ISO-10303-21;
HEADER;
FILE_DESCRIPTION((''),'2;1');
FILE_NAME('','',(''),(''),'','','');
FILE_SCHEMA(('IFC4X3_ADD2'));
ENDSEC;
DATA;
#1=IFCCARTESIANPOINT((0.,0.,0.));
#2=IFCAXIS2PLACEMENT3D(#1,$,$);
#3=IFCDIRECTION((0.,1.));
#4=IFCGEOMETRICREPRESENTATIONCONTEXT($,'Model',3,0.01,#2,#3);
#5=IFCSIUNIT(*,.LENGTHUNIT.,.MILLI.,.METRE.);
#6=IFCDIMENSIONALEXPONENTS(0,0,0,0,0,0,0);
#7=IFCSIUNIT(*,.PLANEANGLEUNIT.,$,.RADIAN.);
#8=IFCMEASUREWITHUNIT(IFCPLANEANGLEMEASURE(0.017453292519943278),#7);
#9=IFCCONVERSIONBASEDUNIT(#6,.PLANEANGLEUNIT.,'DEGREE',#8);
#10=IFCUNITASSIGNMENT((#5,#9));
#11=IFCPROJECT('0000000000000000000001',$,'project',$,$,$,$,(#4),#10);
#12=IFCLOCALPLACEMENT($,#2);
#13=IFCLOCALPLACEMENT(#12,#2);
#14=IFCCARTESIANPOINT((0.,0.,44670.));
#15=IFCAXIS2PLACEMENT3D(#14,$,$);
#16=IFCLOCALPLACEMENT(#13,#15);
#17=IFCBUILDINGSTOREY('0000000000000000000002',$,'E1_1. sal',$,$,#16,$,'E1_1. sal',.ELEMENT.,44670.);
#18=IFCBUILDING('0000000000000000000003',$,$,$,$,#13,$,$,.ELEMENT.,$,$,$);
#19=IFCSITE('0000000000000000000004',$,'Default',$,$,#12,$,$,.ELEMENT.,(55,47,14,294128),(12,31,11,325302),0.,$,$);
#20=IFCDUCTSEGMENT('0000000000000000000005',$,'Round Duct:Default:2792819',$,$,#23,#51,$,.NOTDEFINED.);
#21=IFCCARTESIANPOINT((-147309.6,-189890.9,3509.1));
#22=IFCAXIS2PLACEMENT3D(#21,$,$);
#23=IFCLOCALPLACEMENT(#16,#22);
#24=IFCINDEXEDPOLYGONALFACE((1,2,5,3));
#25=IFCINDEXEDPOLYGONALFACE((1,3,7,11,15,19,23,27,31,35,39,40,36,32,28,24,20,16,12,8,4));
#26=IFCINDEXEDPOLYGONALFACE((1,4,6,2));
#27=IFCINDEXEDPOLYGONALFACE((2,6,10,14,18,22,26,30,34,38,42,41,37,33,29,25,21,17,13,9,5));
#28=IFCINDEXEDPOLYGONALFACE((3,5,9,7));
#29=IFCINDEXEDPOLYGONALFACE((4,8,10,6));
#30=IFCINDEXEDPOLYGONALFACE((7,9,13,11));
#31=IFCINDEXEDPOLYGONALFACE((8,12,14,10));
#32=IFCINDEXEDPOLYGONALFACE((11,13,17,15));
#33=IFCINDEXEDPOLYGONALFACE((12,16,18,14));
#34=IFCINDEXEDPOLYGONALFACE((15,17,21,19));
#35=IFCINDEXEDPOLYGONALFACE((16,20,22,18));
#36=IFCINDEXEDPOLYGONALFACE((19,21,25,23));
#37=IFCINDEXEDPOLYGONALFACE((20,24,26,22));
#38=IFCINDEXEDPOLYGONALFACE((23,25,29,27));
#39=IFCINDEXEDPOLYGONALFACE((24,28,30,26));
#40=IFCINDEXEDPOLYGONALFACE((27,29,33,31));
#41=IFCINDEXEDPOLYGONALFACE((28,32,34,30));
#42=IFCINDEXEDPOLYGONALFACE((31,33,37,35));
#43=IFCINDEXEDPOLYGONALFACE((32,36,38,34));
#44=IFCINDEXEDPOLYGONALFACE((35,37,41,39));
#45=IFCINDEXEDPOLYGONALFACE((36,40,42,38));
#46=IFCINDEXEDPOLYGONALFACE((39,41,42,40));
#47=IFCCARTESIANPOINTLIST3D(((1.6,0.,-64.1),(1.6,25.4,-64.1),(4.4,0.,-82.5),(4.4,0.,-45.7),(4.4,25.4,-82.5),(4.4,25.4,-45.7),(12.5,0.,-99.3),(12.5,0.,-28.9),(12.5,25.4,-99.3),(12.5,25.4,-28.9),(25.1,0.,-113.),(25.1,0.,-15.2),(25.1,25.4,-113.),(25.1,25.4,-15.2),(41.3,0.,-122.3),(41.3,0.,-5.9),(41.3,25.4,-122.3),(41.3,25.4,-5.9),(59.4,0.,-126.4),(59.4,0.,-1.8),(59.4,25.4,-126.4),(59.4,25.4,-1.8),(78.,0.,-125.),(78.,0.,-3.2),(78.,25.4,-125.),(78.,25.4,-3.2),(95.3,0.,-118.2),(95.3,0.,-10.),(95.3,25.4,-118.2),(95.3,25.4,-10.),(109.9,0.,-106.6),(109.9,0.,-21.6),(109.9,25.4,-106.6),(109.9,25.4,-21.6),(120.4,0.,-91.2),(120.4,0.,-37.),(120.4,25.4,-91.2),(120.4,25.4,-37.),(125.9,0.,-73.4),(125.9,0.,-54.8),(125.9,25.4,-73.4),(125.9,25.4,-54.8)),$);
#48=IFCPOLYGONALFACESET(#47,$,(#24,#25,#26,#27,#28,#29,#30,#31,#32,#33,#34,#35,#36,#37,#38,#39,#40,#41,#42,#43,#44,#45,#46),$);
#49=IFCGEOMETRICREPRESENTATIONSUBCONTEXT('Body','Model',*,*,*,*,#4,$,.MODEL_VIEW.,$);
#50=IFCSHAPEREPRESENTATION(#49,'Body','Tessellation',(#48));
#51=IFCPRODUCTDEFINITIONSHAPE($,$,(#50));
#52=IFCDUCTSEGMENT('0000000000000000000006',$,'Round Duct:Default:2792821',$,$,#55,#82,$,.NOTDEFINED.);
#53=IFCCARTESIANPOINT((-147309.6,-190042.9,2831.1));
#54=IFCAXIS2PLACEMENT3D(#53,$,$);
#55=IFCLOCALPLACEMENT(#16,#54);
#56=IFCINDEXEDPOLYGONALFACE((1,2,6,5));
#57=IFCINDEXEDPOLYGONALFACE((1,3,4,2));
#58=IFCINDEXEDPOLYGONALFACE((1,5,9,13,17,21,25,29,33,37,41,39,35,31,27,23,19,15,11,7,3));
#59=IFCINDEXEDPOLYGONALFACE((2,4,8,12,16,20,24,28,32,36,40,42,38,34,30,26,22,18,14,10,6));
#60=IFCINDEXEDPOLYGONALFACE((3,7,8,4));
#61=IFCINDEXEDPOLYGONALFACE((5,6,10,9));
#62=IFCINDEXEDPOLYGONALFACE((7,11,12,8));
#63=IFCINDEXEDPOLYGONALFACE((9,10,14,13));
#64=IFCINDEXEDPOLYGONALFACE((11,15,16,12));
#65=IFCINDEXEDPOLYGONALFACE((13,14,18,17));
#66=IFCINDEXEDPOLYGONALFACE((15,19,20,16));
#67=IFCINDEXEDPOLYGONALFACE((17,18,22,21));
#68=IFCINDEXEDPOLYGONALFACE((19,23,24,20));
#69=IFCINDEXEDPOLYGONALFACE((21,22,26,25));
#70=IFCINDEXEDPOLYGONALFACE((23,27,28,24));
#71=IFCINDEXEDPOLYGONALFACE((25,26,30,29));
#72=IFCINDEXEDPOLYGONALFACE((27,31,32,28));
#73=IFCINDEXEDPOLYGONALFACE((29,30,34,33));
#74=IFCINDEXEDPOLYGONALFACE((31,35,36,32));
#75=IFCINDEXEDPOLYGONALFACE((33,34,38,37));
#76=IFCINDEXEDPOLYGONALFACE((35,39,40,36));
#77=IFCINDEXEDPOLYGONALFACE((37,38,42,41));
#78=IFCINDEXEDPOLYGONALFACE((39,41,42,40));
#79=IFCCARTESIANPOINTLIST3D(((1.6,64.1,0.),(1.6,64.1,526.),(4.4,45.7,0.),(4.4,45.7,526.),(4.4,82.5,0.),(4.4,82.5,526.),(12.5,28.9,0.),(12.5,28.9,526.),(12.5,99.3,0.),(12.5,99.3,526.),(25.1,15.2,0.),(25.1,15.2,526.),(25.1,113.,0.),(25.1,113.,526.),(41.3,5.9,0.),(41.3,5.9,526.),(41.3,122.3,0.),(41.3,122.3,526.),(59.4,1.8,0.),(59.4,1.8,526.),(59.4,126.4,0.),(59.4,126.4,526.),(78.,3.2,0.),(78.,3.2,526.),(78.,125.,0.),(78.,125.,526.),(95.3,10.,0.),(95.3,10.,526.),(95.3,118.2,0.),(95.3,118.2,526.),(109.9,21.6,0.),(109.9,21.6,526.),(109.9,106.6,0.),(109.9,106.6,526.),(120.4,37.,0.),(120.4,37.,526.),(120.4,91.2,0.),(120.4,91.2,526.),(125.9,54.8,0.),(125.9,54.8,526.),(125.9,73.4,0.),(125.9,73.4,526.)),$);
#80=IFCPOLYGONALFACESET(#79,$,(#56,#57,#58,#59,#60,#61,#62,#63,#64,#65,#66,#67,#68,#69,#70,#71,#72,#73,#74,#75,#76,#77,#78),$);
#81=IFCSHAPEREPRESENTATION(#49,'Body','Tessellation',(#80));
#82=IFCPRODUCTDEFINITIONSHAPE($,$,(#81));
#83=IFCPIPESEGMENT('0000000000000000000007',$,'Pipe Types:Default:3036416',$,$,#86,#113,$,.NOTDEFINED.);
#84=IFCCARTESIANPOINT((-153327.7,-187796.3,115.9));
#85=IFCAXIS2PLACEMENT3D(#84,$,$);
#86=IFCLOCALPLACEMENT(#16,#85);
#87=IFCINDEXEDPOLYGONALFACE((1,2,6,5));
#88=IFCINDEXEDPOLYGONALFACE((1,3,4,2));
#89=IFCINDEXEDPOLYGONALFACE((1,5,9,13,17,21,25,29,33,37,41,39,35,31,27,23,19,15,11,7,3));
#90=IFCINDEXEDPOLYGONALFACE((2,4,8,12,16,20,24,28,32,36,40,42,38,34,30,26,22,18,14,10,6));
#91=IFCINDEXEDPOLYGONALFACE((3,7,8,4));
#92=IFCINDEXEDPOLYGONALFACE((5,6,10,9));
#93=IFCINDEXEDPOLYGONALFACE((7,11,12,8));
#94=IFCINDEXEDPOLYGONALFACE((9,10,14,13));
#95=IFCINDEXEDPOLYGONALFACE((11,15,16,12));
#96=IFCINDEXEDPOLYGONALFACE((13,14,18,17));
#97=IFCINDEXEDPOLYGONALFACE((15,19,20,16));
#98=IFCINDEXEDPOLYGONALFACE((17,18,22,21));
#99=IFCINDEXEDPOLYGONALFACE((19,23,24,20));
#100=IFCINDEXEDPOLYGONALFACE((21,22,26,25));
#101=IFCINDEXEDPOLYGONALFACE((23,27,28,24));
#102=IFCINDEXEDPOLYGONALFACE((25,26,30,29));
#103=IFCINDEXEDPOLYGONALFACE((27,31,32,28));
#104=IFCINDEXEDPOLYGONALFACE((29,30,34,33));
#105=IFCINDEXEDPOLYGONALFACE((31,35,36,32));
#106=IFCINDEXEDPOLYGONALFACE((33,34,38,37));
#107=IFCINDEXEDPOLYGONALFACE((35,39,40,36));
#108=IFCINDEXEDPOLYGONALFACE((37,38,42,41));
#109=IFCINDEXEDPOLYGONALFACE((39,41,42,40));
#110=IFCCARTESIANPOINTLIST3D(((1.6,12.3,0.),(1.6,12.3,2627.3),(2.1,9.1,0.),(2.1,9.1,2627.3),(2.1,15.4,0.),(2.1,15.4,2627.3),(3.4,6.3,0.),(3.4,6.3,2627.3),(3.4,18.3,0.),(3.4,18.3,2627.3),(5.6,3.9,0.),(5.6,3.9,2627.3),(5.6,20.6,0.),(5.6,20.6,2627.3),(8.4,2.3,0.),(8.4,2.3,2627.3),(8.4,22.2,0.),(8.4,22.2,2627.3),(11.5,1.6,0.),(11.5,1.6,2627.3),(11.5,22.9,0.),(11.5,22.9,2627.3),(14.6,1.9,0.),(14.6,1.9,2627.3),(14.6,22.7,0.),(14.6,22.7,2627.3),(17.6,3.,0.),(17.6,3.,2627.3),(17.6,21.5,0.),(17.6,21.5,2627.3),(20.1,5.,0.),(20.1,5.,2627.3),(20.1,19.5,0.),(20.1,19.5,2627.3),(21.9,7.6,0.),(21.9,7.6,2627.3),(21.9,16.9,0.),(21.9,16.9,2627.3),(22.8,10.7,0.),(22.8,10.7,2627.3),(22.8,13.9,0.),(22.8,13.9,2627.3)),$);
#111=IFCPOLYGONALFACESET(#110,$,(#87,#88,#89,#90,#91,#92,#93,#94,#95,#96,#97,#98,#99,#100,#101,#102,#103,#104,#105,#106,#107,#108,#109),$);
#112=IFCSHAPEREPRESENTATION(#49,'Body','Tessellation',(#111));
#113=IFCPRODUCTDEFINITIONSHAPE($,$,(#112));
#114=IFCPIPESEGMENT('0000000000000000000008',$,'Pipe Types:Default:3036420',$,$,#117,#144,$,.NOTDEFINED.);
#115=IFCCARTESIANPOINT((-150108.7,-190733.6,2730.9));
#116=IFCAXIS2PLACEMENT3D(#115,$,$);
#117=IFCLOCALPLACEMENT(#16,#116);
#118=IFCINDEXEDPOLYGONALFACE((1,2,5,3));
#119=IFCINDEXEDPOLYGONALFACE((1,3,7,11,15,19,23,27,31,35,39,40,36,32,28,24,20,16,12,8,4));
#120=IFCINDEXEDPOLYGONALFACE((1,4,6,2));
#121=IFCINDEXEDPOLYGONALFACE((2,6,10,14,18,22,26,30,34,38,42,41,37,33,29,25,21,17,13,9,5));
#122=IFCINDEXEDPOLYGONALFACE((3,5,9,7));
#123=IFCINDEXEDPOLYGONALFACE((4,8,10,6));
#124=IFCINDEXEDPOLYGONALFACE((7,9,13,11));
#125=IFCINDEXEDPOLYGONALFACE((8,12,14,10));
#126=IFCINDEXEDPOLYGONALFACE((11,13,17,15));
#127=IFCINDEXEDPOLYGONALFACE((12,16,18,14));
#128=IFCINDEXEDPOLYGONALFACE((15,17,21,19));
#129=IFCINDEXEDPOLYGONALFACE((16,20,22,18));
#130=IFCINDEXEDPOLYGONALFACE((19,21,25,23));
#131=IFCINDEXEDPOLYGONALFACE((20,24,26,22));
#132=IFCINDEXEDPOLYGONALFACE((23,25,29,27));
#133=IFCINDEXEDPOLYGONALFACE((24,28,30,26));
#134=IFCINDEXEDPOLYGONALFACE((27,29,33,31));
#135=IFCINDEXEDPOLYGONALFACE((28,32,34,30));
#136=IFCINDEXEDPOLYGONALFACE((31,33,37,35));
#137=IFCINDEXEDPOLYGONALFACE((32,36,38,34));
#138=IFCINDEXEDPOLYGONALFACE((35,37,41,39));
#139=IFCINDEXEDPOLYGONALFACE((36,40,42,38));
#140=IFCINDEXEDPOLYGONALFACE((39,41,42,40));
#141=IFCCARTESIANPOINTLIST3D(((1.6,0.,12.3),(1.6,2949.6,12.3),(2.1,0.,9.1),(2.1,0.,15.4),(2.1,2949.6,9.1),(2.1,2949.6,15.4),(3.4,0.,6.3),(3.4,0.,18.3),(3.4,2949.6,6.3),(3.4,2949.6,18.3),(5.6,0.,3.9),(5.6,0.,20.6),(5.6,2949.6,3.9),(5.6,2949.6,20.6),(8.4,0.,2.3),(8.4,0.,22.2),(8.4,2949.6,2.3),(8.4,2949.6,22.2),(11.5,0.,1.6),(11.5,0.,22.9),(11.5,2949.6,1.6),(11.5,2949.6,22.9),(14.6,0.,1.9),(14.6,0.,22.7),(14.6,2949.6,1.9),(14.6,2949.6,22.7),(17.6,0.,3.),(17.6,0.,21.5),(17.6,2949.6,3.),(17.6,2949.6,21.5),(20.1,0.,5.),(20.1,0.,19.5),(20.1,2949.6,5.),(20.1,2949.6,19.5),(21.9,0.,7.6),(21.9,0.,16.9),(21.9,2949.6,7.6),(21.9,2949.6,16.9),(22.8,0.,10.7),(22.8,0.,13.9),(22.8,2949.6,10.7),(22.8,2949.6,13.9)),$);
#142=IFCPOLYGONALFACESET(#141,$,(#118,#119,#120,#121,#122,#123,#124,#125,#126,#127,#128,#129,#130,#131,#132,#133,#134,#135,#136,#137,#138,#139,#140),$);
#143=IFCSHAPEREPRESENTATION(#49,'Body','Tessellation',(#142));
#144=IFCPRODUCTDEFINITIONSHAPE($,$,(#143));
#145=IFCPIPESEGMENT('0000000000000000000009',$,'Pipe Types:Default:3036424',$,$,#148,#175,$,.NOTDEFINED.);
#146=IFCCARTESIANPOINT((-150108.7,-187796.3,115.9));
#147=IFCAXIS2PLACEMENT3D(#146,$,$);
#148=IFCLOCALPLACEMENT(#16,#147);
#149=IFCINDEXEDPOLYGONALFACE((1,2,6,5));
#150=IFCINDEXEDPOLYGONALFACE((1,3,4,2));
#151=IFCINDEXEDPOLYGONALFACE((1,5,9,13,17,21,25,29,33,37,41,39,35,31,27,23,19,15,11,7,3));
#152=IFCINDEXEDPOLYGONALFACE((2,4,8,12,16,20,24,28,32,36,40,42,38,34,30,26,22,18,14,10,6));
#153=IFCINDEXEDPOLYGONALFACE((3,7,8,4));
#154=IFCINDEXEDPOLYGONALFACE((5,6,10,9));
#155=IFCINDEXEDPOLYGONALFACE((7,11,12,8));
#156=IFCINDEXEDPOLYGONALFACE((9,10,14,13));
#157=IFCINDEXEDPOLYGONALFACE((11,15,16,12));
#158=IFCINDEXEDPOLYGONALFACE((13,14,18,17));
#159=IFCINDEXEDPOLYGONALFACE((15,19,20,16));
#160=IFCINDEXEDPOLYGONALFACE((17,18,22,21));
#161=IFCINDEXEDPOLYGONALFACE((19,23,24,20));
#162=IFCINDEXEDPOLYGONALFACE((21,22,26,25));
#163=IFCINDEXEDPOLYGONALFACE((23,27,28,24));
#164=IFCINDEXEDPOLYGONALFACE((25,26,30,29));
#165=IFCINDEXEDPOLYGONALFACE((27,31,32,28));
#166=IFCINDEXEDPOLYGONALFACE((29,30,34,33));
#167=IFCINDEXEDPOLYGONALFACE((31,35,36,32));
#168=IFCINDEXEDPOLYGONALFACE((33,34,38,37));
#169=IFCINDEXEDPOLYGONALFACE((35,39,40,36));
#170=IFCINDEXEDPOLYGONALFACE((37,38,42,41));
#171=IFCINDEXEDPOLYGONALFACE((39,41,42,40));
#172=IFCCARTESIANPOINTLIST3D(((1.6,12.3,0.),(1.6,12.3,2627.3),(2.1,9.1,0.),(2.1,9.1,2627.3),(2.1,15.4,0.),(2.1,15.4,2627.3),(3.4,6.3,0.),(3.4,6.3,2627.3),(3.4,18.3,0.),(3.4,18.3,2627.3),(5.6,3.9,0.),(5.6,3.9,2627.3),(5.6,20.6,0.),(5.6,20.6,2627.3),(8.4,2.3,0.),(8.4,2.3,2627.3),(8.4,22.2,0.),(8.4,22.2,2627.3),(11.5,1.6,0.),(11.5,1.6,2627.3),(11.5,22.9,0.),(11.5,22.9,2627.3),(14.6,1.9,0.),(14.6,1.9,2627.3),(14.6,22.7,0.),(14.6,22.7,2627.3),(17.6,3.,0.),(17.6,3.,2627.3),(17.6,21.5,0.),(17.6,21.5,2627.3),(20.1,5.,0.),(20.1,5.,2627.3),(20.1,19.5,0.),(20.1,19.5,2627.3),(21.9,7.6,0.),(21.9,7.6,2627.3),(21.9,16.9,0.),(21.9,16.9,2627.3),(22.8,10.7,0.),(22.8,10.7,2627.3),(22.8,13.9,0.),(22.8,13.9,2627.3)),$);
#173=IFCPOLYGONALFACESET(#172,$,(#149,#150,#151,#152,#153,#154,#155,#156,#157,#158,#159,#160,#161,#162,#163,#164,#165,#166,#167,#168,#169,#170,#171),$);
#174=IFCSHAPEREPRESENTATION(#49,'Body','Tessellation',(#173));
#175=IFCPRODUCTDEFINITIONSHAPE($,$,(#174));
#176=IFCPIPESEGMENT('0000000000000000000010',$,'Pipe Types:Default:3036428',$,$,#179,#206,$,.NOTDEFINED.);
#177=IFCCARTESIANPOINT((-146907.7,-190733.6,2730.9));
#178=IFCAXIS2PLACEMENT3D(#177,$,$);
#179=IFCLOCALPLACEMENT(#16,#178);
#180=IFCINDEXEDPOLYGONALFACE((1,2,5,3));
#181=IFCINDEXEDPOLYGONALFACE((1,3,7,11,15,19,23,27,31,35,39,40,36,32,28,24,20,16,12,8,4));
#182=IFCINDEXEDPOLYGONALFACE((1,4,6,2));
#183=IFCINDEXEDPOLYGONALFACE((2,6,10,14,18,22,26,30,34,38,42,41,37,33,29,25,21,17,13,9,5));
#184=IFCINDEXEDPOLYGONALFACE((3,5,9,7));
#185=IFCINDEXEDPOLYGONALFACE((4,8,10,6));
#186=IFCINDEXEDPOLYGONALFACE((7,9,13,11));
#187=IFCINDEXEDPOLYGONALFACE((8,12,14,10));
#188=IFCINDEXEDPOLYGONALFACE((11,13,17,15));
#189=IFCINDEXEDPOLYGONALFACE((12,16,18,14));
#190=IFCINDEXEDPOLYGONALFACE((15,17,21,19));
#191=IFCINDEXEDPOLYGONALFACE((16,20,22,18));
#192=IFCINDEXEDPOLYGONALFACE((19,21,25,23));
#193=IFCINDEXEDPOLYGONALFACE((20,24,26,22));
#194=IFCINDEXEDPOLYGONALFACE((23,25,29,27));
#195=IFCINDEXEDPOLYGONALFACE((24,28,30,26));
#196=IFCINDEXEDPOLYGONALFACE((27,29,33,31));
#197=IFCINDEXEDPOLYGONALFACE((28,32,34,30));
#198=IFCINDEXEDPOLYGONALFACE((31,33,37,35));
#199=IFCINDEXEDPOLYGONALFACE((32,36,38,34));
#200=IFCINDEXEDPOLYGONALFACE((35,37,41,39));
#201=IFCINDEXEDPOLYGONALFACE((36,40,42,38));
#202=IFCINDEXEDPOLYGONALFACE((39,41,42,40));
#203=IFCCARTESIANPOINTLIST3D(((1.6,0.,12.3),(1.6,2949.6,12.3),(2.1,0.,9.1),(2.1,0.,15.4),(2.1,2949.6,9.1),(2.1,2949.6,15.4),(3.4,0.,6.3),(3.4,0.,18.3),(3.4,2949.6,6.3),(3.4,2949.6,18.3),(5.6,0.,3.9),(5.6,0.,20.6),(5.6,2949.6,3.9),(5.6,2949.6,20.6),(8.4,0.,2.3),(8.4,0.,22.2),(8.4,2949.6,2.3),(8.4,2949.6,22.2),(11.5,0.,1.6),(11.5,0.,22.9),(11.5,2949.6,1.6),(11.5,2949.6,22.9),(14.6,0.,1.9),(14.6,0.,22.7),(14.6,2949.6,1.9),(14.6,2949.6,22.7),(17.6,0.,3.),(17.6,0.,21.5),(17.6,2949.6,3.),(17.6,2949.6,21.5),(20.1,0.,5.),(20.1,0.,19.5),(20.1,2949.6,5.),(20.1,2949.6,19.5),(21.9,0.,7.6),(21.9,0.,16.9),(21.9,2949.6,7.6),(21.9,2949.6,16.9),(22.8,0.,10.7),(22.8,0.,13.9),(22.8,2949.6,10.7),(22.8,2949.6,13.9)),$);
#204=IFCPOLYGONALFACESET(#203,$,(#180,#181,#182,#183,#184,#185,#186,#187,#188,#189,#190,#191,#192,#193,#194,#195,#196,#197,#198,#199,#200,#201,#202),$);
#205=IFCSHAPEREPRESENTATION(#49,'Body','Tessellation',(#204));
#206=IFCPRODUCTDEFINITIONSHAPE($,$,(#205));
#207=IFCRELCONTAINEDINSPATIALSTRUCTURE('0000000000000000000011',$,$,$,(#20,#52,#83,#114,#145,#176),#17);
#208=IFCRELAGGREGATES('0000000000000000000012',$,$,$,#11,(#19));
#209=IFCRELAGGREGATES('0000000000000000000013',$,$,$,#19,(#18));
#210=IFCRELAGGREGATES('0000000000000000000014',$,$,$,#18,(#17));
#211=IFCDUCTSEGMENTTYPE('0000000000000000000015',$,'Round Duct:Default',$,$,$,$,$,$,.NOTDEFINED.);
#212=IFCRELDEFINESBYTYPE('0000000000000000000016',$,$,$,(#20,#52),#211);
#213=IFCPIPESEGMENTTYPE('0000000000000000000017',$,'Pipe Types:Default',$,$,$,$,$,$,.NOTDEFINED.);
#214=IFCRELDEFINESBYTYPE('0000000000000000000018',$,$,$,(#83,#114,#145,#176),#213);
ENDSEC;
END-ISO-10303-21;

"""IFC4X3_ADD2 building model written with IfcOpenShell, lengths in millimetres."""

from ifc_helpers import new_model, entity, si_unit, converted_unit, direction, frame, frame_2d, origin, origin_2d_with_axis, place, context, subcontext, project, spatial, circle, extrude, type_object, element, save


model = new_model("IFC4X3_ADD2")

# Units and contexts
model_context = context("Model", 3, precision=0.01, world=origin(), true_north=direction((0.0, 1.0)))
body_context = subcontext(model_context, "Body", "Model", "MODEL_VIEW")
ifc_project = project(units=[si_unit("LENGTHUNIT", "METRE", prefix="MILLI"), converted_unit("PLANEANGLEUNIT", "DEGREE", entity("IfcPlaneAngleMeasure", 0.017453292519943278), si_unit("PLANEANGLEUNIT", "RADIAN"), dimensions=[0, 0, 0, 0, 0, 0, 0])], contexts=[model_context])

# Site, building, storey
site_placement = place(None, origin())
site = spatial("IfcSite", under=ifc_project, at=site_placement, Name="Default", CompositionType="ELEMENT", RefLatitude=(55, 47, 14, 294128), RefLongitude=(12, 31, 11, 325302), RefElevation=0.0)
building_placement = place(site_placement, origin())
building = spatial("IfcBuilding", under=site, at=building_placement, CompositionType="ELEMENT")
storey_placement = place(building_placement, frame((0.0, 0.0, 44670.0)))
storey = spatial("IfcBuildingStorey", under=building, at=storey_placement, Name="E1_1. sal", LongName="E1_1. sal", CompositionType="ELEMENT", Elevation=44670.0)

# Duct segments
duct_segment_type = type_object("IfcDuctSegmentType", Name="Round Duct:Default", PredefinedType="NOTDEFINED")
duct_segment_1_placement = place(storey_placement, frame((-147309.6, -189890.9, 3509.1)))
element("IfcDuctSegment", 1, at=duct_segment_1_placement, inside=storey, type_object=duct_segment_type, Name="Round Duct:Default:2792819", PredefinedType="NOTDEFINED", context=body_context, shape_type="SweptSolid", body=[
    extrude(circle(Radius=62.5, at=origin_2d_with_axis()), frame((64.1, 0.0, -64.1), z_axis=(0.0, 1.0, 0.0), x_axis=(-1.0, 0.0, 0.0)), (0.0, 0.0, 1.0), 25.4),
])
duct_segment_2_placement = place(storey_placement, frame((-147309.6, -190042.9, 2831.1)))
element("IfcDuctSegment", 2, at=duct_segment_2_placement, inside=storey, type_object=duct_segment_type, Name="Round Duct:Default:2792821", PredefinedType="NOTDEFINED", context=body_context, shape_type="SweptSolid", body=[
    extrude(circle(Radius=62.5, at=origin_2d_with_axis()), frame((64.1, 64.1, 0.0), z_axis=(0.0, 0.0, 1.0), x_axis=(-1.0, 0.0, 0.0)), (0.0, 0.0, 1.0), 526.0),
])

# Pipe segments
pipe_segment_type = type_object("IfcPipeSegmentType", Name="Pipe Types:Default", PredefinedType="NOTDEFINED")
pipe_segment_1_placement = place(storey_placement, frame((-153327.7, -187796.3, 115.9)))
element("IfcPipeSegment", 3, at=pipe_segment_1_placement, inside=storey, type_object=pipe_segment_type, Name="Pipe Types:Default:3036416", PredefinedType="NOTDEFINED", context=body_context, shape_type="SweptSolid", body=[
    extrude(circle(Radius=10.7, at=frame_2d((0.0, 0.0), x_axis=(1.0, 0.0))), frame((12.3, 12.3, 0.0), z_axis=(0.0, 0.0, 1.0), x_axis=(-1.0, 0.0, 0.0)), (0.0, 0.0, 1.0), 2627.3),
])
pipe_segment_2_placement = place(storey_placement, frame((-150108.7, -190733.6, 2730.9)))
element("IfcPipeSegment", 4, at=pipe_segment_2_placement, inside=storey, type_object=pipe_segment_type, Name="Pipe Types:Default:3036420", PredefinedType="NOTDEFINED", context=body_context, shape_type="SweptSolid", body=[
    extrude(circle(Radius=10.7, at=frame_2d((0.0, 0.0), x_axis=(1.0, 0.0))), frame((12.3, 0.0, 12.3), z_axis=(0.0, 1.0, 0.0), x_axis=(-1.0, 0.0, 0.0)), (0.0, 0.0, 1.0), 2949.6),
])
pipe_segment_3_placement = place(storey_placement, frame((-150108.7, -187796.3, 115.9)))
element("IfcPipeSegment", 5, at=pipe_segment_3_placement, inside=storey, type_object=pipe_segment_type, Name="Pipe Types:Default:3036424", PredefinedType="NOTDEFINED", context=body_context, shape_type="SweptSolid", body=[
    extrude(circle(Radius=10.7, at=frame_2d((0.0, 0.0), x_axis=(1.0, 0.0))), frame((12.3, 12.3, 0.0), z_axis=(0.0, 0.0, 1.0), x_axis=(-1.0, 0.0, 0.0)), (0.0, 0.0, 1.0), 2627.3),
])
pipe_segment_4_placement = place(storey_placement, frame((-146907.7, -190733.6, 2730.9)))
element("IfcPipeSegment", 6, at=pipe_segment_4_placement, inside=storey, type_object=pipe_segment_type, Name="Pipe Types:Default:3036428", PredefinedType="NOTDEFINED", context=body_context, shape_type="SweptSolid", body=[
    extrude(circle(Radius=10.7, at=frame_2d((0.0, 0.0), x_axis=(1.0, 0.0))), frame((12.3, 0.0, 12.3), z_axis=(0.0, 1.0, 0.0), x_axis=(-1.0, 0.0, 0.0)), (0.0, 0.0, 1.0), 2949.6),
])

save(model, "model.ifc")
